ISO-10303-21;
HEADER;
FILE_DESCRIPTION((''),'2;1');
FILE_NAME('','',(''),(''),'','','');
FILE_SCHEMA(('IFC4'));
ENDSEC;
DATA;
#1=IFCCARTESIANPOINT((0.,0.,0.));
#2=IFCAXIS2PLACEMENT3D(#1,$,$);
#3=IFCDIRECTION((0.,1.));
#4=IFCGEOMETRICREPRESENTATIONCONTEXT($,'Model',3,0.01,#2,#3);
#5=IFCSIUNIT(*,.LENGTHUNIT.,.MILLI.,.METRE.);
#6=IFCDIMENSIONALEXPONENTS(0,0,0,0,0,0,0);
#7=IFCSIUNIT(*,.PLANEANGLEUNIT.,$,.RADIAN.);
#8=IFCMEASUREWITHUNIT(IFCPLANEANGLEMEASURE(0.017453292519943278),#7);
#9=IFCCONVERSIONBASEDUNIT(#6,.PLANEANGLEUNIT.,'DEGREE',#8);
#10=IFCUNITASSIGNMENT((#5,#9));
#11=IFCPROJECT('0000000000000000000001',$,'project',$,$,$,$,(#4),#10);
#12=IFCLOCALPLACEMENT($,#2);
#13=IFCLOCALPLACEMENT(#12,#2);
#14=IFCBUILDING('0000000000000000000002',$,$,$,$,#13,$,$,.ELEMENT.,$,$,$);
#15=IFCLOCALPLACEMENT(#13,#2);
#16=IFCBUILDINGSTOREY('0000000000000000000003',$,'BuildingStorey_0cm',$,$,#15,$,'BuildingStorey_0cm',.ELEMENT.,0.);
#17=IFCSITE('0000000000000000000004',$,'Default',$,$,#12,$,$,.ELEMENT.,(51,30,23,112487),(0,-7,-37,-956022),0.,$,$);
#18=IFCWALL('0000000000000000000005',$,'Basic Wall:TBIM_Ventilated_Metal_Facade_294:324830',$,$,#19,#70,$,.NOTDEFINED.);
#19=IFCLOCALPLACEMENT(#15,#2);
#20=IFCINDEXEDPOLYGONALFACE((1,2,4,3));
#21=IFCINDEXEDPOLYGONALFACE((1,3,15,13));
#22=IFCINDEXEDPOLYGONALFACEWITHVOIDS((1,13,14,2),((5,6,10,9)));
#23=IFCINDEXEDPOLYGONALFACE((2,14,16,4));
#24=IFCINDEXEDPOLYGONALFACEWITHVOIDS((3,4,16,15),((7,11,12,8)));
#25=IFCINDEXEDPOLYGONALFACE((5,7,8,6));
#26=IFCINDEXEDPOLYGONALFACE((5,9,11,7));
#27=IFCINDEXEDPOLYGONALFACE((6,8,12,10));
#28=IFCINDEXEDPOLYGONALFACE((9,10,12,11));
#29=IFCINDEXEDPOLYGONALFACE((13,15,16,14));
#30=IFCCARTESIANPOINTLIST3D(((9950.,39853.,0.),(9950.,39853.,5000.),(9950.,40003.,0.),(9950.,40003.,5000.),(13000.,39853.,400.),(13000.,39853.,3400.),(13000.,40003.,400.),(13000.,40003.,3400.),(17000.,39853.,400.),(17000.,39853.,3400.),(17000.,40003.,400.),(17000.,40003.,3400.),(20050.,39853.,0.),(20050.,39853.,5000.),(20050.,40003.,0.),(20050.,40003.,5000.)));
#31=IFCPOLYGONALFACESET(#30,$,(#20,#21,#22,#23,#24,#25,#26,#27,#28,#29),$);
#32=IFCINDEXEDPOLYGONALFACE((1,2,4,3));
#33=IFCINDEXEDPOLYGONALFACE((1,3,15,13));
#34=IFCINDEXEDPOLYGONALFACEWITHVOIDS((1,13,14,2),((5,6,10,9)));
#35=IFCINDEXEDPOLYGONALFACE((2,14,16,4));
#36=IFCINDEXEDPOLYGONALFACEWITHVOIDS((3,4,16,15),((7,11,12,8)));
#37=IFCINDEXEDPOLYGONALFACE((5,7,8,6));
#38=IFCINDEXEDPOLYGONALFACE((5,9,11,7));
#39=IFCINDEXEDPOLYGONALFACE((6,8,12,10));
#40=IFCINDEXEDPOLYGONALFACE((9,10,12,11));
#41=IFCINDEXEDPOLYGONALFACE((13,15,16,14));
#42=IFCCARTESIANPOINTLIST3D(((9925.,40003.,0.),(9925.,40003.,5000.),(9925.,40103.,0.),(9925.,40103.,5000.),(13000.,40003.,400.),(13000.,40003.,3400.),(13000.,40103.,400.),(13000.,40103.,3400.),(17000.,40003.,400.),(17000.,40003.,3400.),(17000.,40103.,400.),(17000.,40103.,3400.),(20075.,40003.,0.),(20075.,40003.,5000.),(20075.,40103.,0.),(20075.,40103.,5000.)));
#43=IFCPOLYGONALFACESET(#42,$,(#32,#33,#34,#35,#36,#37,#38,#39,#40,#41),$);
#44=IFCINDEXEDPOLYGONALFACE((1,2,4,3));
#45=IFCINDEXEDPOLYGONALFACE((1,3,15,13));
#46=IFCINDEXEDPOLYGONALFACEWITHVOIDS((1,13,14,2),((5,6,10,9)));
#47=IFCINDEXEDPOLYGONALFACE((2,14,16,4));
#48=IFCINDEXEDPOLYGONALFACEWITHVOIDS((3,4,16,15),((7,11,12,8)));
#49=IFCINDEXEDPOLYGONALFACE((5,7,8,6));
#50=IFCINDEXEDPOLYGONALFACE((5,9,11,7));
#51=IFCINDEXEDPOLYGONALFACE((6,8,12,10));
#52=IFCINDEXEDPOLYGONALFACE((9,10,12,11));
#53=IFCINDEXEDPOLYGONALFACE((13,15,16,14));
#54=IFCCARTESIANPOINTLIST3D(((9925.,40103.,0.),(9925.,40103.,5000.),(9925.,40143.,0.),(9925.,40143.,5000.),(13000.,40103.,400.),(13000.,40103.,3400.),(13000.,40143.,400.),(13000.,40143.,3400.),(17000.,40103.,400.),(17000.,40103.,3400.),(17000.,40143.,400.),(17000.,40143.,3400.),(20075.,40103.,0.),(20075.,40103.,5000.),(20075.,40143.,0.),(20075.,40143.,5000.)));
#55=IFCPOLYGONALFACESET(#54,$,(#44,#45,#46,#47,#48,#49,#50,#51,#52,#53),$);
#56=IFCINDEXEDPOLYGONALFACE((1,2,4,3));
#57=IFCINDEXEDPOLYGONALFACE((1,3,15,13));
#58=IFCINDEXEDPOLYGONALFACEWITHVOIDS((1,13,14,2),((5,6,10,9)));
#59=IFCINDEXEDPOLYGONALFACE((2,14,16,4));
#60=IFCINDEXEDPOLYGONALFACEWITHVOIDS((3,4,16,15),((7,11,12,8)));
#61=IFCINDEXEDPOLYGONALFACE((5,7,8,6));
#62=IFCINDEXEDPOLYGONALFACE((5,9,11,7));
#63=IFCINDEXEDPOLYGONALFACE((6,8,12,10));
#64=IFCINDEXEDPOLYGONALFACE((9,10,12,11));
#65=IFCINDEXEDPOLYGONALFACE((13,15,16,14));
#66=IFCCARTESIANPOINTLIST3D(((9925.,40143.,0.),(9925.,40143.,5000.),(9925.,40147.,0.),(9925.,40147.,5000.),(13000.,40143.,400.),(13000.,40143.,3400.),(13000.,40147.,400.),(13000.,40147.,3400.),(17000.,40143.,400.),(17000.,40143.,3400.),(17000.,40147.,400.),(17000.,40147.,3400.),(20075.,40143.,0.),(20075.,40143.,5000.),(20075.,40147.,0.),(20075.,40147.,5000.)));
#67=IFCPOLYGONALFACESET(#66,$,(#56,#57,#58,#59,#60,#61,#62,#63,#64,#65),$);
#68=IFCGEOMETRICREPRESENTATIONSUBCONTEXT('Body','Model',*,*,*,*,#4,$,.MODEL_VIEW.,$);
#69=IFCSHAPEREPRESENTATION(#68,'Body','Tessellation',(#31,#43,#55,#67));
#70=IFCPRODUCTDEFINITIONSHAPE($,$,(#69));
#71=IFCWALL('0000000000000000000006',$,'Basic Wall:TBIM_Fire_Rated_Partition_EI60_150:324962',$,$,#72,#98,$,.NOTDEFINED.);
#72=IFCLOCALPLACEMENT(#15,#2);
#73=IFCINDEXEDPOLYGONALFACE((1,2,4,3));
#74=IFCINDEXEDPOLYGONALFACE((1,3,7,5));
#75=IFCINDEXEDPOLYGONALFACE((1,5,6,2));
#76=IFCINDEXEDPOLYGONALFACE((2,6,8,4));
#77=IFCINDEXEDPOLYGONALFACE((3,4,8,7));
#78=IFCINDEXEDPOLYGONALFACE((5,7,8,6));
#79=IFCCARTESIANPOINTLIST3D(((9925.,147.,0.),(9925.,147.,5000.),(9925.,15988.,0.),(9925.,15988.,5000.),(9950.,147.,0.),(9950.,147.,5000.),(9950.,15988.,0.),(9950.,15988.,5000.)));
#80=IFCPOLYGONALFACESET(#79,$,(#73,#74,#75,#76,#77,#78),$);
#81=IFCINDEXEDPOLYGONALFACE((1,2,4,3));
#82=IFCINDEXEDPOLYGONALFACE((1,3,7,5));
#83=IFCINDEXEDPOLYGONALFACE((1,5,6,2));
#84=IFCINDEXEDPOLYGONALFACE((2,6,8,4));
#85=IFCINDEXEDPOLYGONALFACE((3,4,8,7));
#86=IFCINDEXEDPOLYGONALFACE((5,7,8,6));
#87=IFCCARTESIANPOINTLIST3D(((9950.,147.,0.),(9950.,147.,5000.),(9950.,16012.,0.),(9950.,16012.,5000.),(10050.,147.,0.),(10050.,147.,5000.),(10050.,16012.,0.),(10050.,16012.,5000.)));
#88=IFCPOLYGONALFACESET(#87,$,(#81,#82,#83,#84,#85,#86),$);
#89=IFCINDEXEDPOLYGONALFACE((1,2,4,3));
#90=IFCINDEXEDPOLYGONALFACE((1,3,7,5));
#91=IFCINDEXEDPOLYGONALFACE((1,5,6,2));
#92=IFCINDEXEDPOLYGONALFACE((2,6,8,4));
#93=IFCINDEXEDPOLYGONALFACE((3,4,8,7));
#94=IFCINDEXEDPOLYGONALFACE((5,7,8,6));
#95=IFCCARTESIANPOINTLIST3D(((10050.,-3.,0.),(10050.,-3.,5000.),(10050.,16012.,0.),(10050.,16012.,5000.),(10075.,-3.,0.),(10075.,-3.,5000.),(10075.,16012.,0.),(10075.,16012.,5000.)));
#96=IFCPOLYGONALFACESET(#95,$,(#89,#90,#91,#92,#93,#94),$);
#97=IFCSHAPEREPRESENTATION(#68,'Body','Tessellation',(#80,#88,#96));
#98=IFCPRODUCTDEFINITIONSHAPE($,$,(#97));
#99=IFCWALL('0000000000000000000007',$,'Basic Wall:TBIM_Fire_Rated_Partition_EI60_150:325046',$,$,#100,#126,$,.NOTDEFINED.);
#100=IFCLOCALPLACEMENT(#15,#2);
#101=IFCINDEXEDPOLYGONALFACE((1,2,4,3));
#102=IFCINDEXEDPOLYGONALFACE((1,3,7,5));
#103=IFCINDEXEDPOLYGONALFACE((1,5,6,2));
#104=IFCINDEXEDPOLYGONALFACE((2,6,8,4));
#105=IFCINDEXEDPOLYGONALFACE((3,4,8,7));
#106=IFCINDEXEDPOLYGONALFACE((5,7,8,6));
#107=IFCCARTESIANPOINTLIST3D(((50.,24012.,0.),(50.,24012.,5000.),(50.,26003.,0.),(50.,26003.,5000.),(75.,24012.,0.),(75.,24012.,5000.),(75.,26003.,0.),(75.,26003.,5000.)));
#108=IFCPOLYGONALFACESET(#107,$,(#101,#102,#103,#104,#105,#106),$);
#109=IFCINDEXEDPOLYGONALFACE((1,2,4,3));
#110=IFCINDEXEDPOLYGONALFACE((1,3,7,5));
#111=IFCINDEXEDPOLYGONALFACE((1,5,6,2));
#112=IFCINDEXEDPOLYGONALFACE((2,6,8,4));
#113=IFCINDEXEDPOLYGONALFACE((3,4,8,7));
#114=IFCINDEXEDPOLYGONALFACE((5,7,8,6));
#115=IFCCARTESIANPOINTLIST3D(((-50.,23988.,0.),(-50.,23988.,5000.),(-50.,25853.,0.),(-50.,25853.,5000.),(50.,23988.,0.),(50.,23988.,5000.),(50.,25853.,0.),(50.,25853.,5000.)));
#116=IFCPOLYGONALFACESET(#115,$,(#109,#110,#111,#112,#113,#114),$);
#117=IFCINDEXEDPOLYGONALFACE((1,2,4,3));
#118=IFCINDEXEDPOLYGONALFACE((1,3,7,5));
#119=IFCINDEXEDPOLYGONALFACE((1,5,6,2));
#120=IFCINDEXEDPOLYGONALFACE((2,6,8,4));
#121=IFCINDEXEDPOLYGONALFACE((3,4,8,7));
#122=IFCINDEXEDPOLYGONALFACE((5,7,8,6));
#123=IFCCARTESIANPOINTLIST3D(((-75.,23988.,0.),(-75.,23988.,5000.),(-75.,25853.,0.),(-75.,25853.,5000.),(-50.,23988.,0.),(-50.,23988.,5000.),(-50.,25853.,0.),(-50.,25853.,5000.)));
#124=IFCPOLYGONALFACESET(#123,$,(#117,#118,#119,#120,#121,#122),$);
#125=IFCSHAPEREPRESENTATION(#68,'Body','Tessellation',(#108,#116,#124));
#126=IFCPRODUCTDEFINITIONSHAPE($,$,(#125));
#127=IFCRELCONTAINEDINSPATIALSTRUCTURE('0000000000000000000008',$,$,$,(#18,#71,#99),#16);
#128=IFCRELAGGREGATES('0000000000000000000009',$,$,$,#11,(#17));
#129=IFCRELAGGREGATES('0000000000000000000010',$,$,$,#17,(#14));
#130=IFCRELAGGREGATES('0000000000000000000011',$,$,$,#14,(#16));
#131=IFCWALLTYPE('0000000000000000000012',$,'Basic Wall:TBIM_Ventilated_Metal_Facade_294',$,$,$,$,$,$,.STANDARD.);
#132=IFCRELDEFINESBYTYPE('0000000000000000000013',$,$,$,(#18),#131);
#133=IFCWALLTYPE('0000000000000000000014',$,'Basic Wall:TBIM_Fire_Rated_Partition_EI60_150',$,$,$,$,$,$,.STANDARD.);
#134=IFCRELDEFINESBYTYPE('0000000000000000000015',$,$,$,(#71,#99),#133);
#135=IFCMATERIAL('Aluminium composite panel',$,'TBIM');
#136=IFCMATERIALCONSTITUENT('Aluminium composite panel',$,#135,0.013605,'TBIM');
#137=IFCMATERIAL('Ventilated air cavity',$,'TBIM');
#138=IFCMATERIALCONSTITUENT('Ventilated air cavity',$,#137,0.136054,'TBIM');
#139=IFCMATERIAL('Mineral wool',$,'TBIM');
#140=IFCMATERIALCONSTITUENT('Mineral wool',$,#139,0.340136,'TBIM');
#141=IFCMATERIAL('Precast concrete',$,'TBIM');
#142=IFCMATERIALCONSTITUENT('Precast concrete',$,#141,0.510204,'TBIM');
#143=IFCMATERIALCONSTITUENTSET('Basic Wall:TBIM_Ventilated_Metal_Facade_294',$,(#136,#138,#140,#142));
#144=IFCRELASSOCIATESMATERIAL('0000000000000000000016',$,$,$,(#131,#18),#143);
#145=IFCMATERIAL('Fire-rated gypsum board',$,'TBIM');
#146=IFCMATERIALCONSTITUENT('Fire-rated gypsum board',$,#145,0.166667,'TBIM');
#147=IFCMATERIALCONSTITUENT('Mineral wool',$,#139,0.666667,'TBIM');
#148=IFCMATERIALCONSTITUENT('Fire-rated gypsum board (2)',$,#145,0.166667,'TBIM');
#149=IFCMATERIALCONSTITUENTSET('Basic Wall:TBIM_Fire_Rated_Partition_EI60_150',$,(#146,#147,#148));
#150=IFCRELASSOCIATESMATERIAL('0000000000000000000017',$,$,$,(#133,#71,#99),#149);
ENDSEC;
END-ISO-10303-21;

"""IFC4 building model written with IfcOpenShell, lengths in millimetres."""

from ifc_helpers import new_model, entity, si_unit, converted_unit, direction, frame, origin, place, context, subcontext, project, spatial, indexed_curve, outline, extrude, material, constituent, constituent_set, type_object, element, save


model = new_model("IFC4")

# Units and contexts
model_context = context("Model", 3, precision=0.01, world=origin(), true_north=direction((0.0, 1.0)))
body_context = subcontext(model_context, "Body", "Model", "MODEL_VIEW")
ifc_project = project(units=[si_unit("LENGTHUNIT", "METRE", prefix="MILLI"), converted_unit("PLANEANGLEUNIT", "DEGREE", entity("IfcPlaneAngleMeasure", 0.017453292519943278), si_unit("PLANEANGLEUNIT", "RADIAN"), dimensions=[0, 0, 0, 0, 0, 0, 0])], contexts=[model_context])

# Site, building, storey
site_placement = place(None, origin())
site = spatial("IfcSite", under=ifc_project, at=site_placement, Name="Default", CompositionType="ELEMENT", RefLatitude=(51, 30, 23, 112487), RefLongitude=(0, -7, -37, -956022), RefElevation=0.0)
building_placement = place(site_placement, origin())
building = spatial("IfcBuilding", under=site, at=building_placement, CompositionType="ELEMENT")
storey_placement = place(building_placement, origin())
storey = spatial("IfcBuildingStorey", under=building, at=storey_placement, Name="BuildingStorey_0cm", LongName="BuildingStorey_0cm", CompositionType="ELEMENT", Elevation=0.0)

# Wall, opening
ifc_material_1 = material(Name="Aluminium composite panel", Category="TBIM")
ifc_constituent_1 = constituent(ifc_material_1, Name="Aluminium composite panel", Category="TBIM", fraction=0.013605)
ifc_material_2 = material(Name="Ventilated air cavity", Category="TBIM")
ifc_constituent_2 = constituent(ifc_material_2, Name="Ventilated air cavity", Category="TBIM", fraction=0.136054)
ifc_material_3 = material(Name="Mineral wool", Category="TBIM")
ifc_constituent_3 = constituent(ifc_material_3, Name="Mineral wool", Category="TBIM", fraction=0.340136)
ifc_material_4 = material(Name="Precast concrete", Category="TBIM")
ifc_constituent_4 = constituent(ifc_material_4, Name="Precast concrete", Category="TBIM", fraction=0.510204)
ifc_constituent_set_1 = constituent_set(constituents=[ifc_constituent_1, ifc_constituent_2, ifc_constituent_3, ifc_constituent_4], Name="Basic Wall:TBIM_Ventilated_Metal_Facade_294")
wall_type_1 = type_object("IfcWallType", Name="Basic Wall:TBIM_Ventilated_Metal_Facade_294", PredefinedType="STANDARD", material=ifc_constituent_set_1)
wall_1_placement = place(storey_placement, frame((9925.0, 40000.0, 0.0)))
wall_1 = element("IfcWall", 1, at=wall_1_placement, inside=storey, type_object=wall_type_1, material=ifc_constituent_set_1, Name="Basic Wall:TBIM_Ventilated_Metal_Facade_294:324830", PredefinedType="NOTDEFINED", context=body_context, shape_type="SweptSolid", body=[
    extrude(outline(indexed_curve([(-2500.0, -5050.0), (2500.0, -5050.0), (2500.0, -4925.0), (2500.0, 4925.0), (2500.0, 5050.0), (-2500.0, 5050.0), (-2500.0, 4925.0), (-2500.0, -4925.0), (-2500.0, -5050.0)], self_intersect=False), holes=[indexed_curve([(900.0, -2000.0), (-2100.0, -2000.0), (-2100.0, 2000.0), (900.0, 2000.0), (900.0, -2000.0)], self_intersect=False)]), frame((5075.0, -147.0, 2500.0), z_axis=(0.0, 1.0, 0.0), x_axis=(0.0, 0.0, 1.0)), (0.0, 0.0, 1.0), 150.0),
    extrude(outline(indexed_curve([(-2500.0, -5075.0), (2500.0, -5075.0), (2500.0, 5075.0), (-2500.0, 5075.0), (-2500.0, -5075.0)], self_intersect=False), holes=[indexed_curve([(-2100.0, -2000.0), (-2100.0, 2000.0), (900.0, 2000.0), (900.0, -2000.0), (-2100.0, -2000.0)], self_intersect=False)]), frame((5075.0, 3.0, 2500.0), z_axis=(0.0, 1.0, 0.0), x_axis=(0.0, 0.0, 1.0)), (0.0, 0.0, 1.0), 100.0),
    extrude(outline(indexed_curve([(-2500.0, -5075.0), (2500.0, -5075.0), (2500.0, 5075.0), (-2500.0, 5075.0), (-2500.0, -5075.0)], self_intersect=False), holes=[indexed_curve([(-2100.0, -2000.0), (-2100.0, 2000.0), (900.0, 2000.0), (900.0, -2000.0), (-2100.0, -2000.0)], self_intersect=False)]), frame((5075.0, 103.0, 2500.0), z_axis=(0.0, 1.0, 0.0), x_axis=(0.0, 0.0, 1.0)), (0.0, 0.0, 1.0), 40.0),
    extrude(outline(indexed_curve([(-2500.0, -5075.0), (2500.0, -5075.0), (2500.0, 5075.0), (-2500.0, 5075.0), (-2500.0, -5075.0)], self_intersect=False), holes=[indexed_curve([(-2100.0, -2000.0), (-2100.0, 2000.0), (900.0, 2000.0), (900.0, -2000.0), (-2100.0, -2000.0)], self_intersect=False)]), frame((5075.0, 143.0, 2500.0), z_axis=(0.0, 1.0, 0.0), x_axis=(0.0, 0.0, 1.0)), (0.0, 0.0, 1.0), 4.0),
])
opening_1_placement = place(wall_1_placement, frame((3075.0, -147.0, 400.0)))
element("IfcOpeningElement", 2, at=opening_1_placement, cuts=wall_1, PredefinedType="OPENING", context=body_context, shape_type="SweptSolid", body=[
    extrude(outline(indexed_curve([(3000.0, 0.0), (3000.0, 4000.0), (0.0, 4000.0), (0.0, 0.0), (3000.0, 0.0)], self_intersect=False)), frame((0.0, 0.0, 0.0), z_axis=(0.0, 1.0, 0.0), x_axis=(0.0, 0.0, 1.0)), (0.0, 0.0, 1.0), 294.0),
])

# Walls
ifc_material_5 = material(Name="Fire-rated gypsum board", Category="TBIM")
ifc_constituent_5 = constituent(ifc_material_5, Name="Fire-rated gypsum board", Category="TBIM", fraction=0.166667)
ifc_constituent_6 = constituent(ifc_material_3, Name="Mineral wool", Category="TBIM", fraction=0.666667)
ifc_constituent_7 = constituent(ifc_material_5, Name="Fire-rated gypsum board (2)", Category="TBIM", fraction=0.166667)
ifc_constituent_set_2 = constituent_set(constituents=[ifc_constituent_5, ifc_constituent_6, ifc_constituent_7], Name="Basic Wall:TBIM_Fire_Rated_Partition_EI60_150")
wall_type_2 = type_object("IfcWallType", Name="Basic Wall:TBIM_Fire_Rated_Partition_EI60_150", PredefinedType="STANDARD", material=ifc_constituent_set_2)
wall_2_placement = place(storey_placement, frame((10000.0, 147.0, 0.0), z_axis=(0.0, 0.0, 1.0), x_axis=(0.0, 1.0, 0.0)))
element("IfcWall", 3, at=wall_2_placement, inside=storey, type_object=wall_type_2, material=ifc_constituent_set_2, Name="Basic Wall:TBIM_Fire_Rated_Partition_EI60_150:324962", PredefinedType="NOTDEFINED", context=body_context, shape_type="SweptSolid", body=[
    extrude(outline(indexed_curve([(-12.5, -7920.5), (12.5, -7920.5), (12.5, 7920.5), (-12.5, 7920.5), (-12.5, -7920.5)], self_intersect=False)), frame((7920.5, 62.5, 0.0), z_axis=(0.0, 0.0, 1.0), x_axis=(0.0, -1.0, 0.0)), (0.0, 0.0, 1.0), 5000.0),
    extrude(outline(indexed_curve([(-7932.5, -50.0), (7932.5, -50.0), (7932.5, 50.0), (-7932.5, 50.0), (-7932.5, -50.0)], self_intersect=False)), frame((7932.5, 0.0, 0.0)), (0.0, 0.0, 1.0), 5000.0),
    extrude(outline(indexed_curve([(-12.5, -8007.5), (12.5, -8007.5), (12.5, 8007.5), (-12.5, 8007.5), (-12.5, -8007.5)], self_intersect=False)), frame((7857.5, -62.5, 0.0), z_axis=(0.0, 0.0, 1.0), x_axis=(0.0, 1.0, 0.0)), (0.0, 0.0, 1.0), 5000.0),
])
wall_3_placement = place(storey_placement, frame((0.0, 25853.0, 0.0), z_axis=(0.0, 0.0, 1.0), x_axis=(0.0, -1.0, 0.0)))
element("IfcWall", 4, at=wall_3_placement, inside=storey, type_object=wall_type_2, material=ifc_constituent_set_2, Name="Basic Wall:TBIM_Fire_Rated_Partition_EI60_150:325046", PredefinedType="NOTDEFINED", context=body_context, shape_type="SweptSolid", body=[
    extrude(outline(indexed_curve([(-12.5, -995.5), (12.5, -995.5), (12.5, 995.5), (-12.5, 995.5), (-12.5, -995.5)], self_intersect=False)), frame((845.5, 62.5, 0.0), z_axis=(0.0, 0.0, 1.0), x_axis=(0.0, -1.0, 0.0)), (0.0, 0.0, 1.0), 5000.0),
    extrude(outline(indexed_curve([(-932.5, -50.0), (932.5, -50.0), (932.5, 50.0), (-932.5, 50.0), (-932.5, -50.0)], self_intersect=False)), frame((932.5, 0.0, 0.0)), (0.0, 0.0, 1.0), 5000.0),
    extrude(outline(indexed_curve([(-12.5, -932.5), (12.5, -932.5), (12.5, 932.5), (-12.5, 932.5), (-12.5, -932.5)], self_intersect=False)), frame((932.5, -62.5, 0.0), z_axis=(0.0, 0.0, 1.0), x_axis=(0.0, 1.0, 0.0)), (0.0, 0.0, 1.0), 5000.0),
])

save(model, "model.ifc")
